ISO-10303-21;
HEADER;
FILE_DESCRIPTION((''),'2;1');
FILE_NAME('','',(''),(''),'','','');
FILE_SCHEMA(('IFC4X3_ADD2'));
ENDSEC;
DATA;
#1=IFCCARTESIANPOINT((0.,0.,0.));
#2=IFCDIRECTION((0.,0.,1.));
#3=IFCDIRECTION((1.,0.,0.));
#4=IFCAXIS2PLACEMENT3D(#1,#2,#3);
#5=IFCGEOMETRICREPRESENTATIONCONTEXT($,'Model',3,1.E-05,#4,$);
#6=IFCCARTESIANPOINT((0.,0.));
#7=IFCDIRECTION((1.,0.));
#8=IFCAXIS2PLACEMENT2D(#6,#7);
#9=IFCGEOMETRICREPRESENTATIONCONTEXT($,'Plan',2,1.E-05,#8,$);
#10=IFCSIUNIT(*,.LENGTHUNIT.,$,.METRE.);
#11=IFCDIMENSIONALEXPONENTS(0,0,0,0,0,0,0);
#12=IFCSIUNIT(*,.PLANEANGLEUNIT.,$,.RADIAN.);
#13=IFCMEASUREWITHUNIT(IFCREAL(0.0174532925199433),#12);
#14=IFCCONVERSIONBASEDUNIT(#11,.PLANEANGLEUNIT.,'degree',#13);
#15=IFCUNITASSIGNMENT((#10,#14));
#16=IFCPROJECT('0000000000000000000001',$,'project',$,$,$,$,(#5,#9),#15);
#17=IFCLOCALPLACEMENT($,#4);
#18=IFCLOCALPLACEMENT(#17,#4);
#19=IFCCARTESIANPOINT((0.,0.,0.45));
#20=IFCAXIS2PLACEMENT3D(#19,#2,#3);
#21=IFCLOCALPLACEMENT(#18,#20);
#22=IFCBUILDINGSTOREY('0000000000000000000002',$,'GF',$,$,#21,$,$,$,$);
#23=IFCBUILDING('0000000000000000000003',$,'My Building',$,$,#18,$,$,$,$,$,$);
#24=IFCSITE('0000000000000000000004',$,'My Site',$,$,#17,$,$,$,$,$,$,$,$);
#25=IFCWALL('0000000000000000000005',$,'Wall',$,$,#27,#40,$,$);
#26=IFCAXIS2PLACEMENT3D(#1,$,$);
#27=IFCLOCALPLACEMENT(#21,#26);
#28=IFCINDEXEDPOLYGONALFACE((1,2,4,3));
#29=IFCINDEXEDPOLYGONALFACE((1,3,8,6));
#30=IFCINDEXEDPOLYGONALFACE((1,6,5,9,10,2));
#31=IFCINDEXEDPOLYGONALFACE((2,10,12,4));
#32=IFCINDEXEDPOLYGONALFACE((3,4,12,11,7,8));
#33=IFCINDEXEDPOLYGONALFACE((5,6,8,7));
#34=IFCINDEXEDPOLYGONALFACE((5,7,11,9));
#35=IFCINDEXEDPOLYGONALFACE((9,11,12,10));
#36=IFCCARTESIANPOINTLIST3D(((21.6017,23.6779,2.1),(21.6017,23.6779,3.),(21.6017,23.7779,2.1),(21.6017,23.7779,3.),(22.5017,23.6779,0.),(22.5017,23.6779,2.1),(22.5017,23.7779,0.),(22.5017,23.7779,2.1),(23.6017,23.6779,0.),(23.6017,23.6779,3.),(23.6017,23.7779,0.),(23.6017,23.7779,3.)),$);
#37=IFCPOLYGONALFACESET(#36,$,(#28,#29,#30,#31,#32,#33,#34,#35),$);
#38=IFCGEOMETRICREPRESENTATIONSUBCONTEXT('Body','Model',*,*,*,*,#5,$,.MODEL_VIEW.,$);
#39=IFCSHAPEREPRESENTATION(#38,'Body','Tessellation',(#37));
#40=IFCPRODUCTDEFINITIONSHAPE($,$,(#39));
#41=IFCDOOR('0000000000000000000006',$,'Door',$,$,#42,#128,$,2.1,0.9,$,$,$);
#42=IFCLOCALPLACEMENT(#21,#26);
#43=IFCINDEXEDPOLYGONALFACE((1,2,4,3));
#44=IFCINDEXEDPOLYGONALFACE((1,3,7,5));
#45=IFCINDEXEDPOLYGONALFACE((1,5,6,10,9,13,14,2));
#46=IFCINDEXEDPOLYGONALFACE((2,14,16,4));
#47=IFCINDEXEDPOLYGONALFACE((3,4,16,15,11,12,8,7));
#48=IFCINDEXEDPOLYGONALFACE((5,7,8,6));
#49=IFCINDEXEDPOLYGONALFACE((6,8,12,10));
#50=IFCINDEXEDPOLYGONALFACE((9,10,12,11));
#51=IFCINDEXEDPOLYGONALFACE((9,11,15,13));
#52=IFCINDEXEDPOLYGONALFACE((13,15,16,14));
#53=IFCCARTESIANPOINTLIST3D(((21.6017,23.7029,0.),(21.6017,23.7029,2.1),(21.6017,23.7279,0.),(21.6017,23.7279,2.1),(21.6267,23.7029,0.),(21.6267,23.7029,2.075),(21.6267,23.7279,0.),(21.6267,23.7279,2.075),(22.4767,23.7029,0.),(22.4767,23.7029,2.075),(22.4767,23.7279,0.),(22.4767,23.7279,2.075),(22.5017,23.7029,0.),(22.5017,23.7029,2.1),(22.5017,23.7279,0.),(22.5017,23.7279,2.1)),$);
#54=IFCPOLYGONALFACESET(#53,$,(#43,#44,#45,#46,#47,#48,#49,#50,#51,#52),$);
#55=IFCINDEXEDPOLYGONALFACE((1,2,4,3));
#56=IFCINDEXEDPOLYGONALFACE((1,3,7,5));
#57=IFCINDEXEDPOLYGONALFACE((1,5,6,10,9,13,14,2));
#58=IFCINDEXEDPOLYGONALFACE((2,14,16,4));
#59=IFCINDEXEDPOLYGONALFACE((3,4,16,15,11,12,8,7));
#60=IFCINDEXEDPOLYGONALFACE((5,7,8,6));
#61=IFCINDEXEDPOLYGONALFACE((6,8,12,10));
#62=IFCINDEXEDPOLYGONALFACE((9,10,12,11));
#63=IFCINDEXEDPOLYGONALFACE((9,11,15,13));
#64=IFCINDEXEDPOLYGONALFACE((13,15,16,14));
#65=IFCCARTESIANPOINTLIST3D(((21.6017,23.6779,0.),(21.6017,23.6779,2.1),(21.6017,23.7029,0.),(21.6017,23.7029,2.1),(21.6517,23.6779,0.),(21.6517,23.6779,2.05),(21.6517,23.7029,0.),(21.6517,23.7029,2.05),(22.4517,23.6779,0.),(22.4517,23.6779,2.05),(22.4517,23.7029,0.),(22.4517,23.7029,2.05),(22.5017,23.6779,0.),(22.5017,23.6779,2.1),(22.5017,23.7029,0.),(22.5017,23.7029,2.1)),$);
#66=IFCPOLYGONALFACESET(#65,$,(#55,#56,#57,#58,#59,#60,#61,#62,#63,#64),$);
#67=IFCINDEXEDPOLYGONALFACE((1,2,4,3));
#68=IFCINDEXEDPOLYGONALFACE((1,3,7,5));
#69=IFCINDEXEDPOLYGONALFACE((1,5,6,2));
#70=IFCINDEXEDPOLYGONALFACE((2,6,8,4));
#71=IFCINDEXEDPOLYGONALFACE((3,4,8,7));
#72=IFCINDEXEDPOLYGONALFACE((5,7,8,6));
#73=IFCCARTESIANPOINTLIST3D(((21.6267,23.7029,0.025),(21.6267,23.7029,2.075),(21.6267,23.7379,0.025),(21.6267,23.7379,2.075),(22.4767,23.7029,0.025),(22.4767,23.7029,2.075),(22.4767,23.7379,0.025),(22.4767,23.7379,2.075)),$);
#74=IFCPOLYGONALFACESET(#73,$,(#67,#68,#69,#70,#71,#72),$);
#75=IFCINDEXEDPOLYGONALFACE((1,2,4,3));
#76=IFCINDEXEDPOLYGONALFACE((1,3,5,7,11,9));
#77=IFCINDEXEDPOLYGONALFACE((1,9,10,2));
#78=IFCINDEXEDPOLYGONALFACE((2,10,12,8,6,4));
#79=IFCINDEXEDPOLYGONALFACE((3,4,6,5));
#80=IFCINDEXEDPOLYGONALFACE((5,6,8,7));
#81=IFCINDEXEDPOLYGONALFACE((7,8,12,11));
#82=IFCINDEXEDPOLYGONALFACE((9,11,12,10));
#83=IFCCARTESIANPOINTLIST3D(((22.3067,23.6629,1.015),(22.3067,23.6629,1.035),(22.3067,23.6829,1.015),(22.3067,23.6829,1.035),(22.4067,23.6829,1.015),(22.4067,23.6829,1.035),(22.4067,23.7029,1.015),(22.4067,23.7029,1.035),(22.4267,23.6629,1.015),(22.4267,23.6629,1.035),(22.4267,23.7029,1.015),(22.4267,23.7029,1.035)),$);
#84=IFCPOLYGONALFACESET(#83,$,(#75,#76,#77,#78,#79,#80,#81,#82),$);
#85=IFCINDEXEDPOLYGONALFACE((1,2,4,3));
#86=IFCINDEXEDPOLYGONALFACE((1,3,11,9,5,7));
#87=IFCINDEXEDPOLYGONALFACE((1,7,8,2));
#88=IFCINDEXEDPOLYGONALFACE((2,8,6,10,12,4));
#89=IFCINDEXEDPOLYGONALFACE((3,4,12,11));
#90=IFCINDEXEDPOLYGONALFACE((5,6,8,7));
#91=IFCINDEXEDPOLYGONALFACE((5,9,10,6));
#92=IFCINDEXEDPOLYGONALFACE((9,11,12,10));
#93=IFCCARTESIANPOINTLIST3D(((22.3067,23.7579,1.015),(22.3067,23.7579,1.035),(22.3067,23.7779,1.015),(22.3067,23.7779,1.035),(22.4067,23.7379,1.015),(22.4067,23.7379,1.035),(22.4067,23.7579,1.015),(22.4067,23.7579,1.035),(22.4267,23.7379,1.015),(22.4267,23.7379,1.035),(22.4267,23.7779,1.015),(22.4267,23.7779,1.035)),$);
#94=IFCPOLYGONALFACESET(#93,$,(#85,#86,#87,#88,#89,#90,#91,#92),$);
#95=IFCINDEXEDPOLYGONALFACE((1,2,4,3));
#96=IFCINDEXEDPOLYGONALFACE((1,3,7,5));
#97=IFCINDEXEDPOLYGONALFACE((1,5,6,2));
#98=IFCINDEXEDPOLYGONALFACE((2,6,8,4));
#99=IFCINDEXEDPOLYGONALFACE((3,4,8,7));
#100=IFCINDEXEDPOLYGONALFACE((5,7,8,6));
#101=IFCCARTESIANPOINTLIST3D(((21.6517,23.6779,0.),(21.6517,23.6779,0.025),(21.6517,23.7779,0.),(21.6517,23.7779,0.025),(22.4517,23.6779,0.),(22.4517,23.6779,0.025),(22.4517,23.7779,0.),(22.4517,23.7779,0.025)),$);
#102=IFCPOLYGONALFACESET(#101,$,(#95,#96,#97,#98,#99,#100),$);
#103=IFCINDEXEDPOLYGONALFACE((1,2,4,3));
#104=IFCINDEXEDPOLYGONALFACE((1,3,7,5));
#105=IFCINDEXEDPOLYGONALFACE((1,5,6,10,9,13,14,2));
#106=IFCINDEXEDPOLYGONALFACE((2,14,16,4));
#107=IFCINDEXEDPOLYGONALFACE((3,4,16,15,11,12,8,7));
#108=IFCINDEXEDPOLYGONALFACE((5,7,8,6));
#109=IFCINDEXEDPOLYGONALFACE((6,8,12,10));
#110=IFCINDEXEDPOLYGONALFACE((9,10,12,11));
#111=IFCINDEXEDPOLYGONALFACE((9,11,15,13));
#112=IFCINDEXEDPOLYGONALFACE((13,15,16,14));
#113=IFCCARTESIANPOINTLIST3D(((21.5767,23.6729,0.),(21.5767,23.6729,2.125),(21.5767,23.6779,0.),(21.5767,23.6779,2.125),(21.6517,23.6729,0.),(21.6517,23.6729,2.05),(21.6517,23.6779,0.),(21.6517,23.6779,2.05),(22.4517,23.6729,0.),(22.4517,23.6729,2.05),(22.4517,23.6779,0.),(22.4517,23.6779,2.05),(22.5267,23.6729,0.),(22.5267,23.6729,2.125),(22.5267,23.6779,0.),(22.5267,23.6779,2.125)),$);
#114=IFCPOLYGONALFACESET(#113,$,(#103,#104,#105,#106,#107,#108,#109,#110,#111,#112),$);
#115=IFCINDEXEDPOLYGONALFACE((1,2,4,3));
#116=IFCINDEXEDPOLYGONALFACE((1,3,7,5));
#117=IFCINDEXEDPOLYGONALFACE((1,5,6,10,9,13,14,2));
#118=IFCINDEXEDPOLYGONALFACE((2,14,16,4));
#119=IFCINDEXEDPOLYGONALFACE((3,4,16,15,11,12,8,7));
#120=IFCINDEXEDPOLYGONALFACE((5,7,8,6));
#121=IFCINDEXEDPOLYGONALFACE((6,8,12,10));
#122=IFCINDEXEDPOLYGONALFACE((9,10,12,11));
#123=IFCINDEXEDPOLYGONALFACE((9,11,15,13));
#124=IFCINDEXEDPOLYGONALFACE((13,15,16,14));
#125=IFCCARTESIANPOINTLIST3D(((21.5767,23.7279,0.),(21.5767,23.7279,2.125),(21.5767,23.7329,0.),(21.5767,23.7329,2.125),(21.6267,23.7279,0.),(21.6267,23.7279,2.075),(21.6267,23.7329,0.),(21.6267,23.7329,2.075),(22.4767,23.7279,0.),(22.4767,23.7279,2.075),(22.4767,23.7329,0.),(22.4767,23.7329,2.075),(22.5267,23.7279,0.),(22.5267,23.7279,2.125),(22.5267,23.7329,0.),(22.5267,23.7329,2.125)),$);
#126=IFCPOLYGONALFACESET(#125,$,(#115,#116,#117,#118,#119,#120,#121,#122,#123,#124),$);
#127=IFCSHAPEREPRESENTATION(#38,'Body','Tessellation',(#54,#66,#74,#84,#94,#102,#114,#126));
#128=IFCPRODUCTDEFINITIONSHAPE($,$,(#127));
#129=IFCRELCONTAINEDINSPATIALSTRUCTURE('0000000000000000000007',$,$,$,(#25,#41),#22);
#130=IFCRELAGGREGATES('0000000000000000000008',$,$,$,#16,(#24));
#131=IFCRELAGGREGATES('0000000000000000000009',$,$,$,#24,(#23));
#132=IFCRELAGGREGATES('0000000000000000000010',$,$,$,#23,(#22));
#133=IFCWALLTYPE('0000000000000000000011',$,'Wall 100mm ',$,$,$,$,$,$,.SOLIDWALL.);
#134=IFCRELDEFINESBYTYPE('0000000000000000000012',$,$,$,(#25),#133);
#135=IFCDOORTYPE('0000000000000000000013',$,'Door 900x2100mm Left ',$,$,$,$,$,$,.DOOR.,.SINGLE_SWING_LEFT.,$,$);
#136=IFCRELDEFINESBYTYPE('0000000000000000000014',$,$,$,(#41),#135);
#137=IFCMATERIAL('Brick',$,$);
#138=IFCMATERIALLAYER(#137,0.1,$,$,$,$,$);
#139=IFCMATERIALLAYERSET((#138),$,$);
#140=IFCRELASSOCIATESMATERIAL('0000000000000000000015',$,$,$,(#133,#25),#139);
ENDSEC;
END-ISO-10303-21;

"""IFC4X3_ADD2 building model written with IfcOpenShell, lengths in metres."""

from ifc_helpers import new_model, entity, si_unit, converted_unit, frame, origin_with_axes, origin_2d_with_axis, place, context, subcontext, project, spatial, line, indexed_curve, outline, extrude, shape, source, transform, mapped, material, layer, layer_set, layer_usage, type_object, type_shapes, element, fill, save


model = new_model("IFC4X3_ADD2")

# Units and contexts
model_context = context("Model", 3, precision=1e-05, world=origin_with_axes())
plan_context = context("Plan", 2, precision=1e-05, world=origin_2d_with_axis())
body_context_1 = subcontext(model_context, "Body", "Model", "MODEL_VIEW")
body_context_2 = subcontext(plan_context, "Body", "Plan", "PLAN_VIEW")
ifc_project = project(units=[si_unit("LENGTHUNIT", "METRE"), converted_unit("PLANEANGLEUNIT", "degree", entity("IfcReal", 0.0174532925199433), si_unit("PLANEANGLEUNIT", "RADIAN"), dimensions=[0, 0, 0, 0, 0, 0, 0])], contexts=[model_context, plan_context])

# Site, building, storey
site_placement = place(None, origin_with_axes())
site = spatial("IfcSite", under=ifc_project, at=site_placement, Name="My Site")
building_placement = place(site_placement, origin_with_axes())
building = spatial("IfcBuilding", under=site, at=building_placement, Name="My Building")
storey_placement = place(building_placement, frame((0.0, 0.0, 0.45), z_axis=(0.0, 0.0, 1.0), x_axis=(1.0, 0.0, 0.0)))
storey = spatial("IfcBuildingStorey", under=building, at=storey_placement, Name="GF")

# Shared definitions
ifc_material = material(Name="Brick")

# Shared definitions
ifc_layer_1 = layer(ifc_material, 0.1)
ifc_layer_set_1 = layer_set([ifc_layer_1])
wall_type_1 = type_object("IfcWallType", Name="Wall 100mm ", PredefinedType="SOLIDWALL", material=ifc_layer_set_1)

# Wall, opening, door
ifc_layer_usage_1 = layer_usage(ifc_layer_set_1, "AXIS2", "POSITIVE", 0.0)
wall_1_placement = place(storey_placement, frame((21.6017, 23.6779, 0.0), z_axis=(0.0, 0.0, 1.0), x_axis=(1.0, 0.0, 0.0)))
wall_1 = element("IfcWall", 1, at=wall_1_placement, inside=storey, type_object=wall_type_1, material=ifc_layer_usage_1, Name="Wall", context=body_context_1, shape_type="SweptSolid", body=[
    extrude(outline(indexed_curve([(0.0, 0.0), (0.0, 0.1), (2.0, 0.1), (2.0, 0.0), (0.0, 0.0)], self_intersect=False)), origin_with_axes(), (0.0, 0.0, 1.0), 3.0),
])
shared_shape_1 = source(origin_with_axes(), body_context_1, "Body", "SweptSolid", [
    extrude(outline(indexed_curve([(0.0, 0.0), (0.9, 0.0), (0.9, 2.1), (0.0, 2.1)], segments=[line(1, 2, 3, 4, 1)])), frame((0.0, -0.6, 0.0), z_axis=(0.0, -1.0, 0.0), x_axis=(1.0, 0.0, 0.0)), (0.0, 0.0, -1.0), 1.2),
])
opening_1_placement = place(wall_1_placement, frame((0.0, 0.0, 0.0), z_axis=(0.0, 0.0, 1.0), x_axis=(1.0, 0.0, 0.0)))
opening_1 = element("IfcOpeningElement", 2, at=opening_1_placement, cuts=wall_1, PredefinedType="OPENING", context=body_context_1, shape_type="MappedRepresentation", body=[
    mapped(shared_shape_1, transform((0.0, 0.0, 0.0), x_axis=(1.0, 0.0, 0.0), y_axis=(0.0, 1.0, 0.0), z_axis=(0.0, 0.0, 1.0), scale=1.0)),
])
door_type_1 = type_object("IfcDoorType", Name="Door 900x2100mm Left ", OperationType="SINGLE_SWING_LEFT", PredefinedType="DOOR")
shared_shape_2 = source(origin_with_axes(), body_context_1, "Body", "SweptSolid", [
    extrude(outline(indexed_curve([(0.0, 0.0), (0.0, 2.1), (0.9, 2.1), (0.9, 0.0), (0.875, 0.0), (0.875, 2.075), (0.025, 2.075), (0.025, 0.0)], segments=[line(1, 2, 3, 4, 5, 6, 7, 8, 1)])), frame((0.0, 0.025, 0.0), z_axis=(0.0, -1.0, 0.0), x_axis=(1.0, 0.0, 0.0)), (0.0, 0.0, -1.0), 0.025),
    extrude(outline(indexed_curve([(0.0, 0.0), (0.0, 2.1), (0.9, 2.1), (0.9, 0.0), (0.85, 0.0), (0.85, 2.05), (0.05, 2.05), (0.05, 0.0)], segments=[line(1, 2, 3, 4, 5, 6, 7, 8, 1)])), frame((0.0, 0.0, 0.0), z_axis=(0.0, -1.0, 0.0), x_axis=(1.0, 0.0, 0.0)), (0.0, 0.0, -1.0), 0.025),
    extrude(outline(indexed_curve([(0.0, 0.0), (0.85, 0.0), (0.85, 0.035), (0.0, 0.035)], segments=[line(1, 2, 3, 4, 1)])), frame((0.025, 0.025, 0.025), z_axis=(0.0, 0.0, 1.0), x_axis=(1.0, 0.0, 0.0)), (0.0, 0.0, 1.0), 2.05),
    extrude(outline(indexed_curve([(0.0, 0.0), (0.0, -0.04), (-0.12, -0.04), (-0.12, -0.02), (-0.02, -0.02), (-0.02, 0.0)], segments=[line(1, 2, 3, 4, 5, 6, 1)])), frame((0.825, 0.025, 1.015), z_axis=(0.0, 0.0, 1.0), x_axis=(1.0, 0.0, 0.0)), (0.0, 0.0, 1.0), 0.02),
    extrude(outline(indexed_curve([(0.0, 0.0), (0.0, 0.04), (-0.12, 0.04), (-0.12, 0.02), (-0.02, 0.02), (-0.02, 0.0)], segments=[line(1, 2, 3, 4, 5, 6, 1)])), frame((0.825, 0.06, 1.015), z_axis=(0.0, 0.0, 1.0), x_axis=(1.0, 0.0, 0.0)), (0.0, 0.0, 1.0), 0.02),
    extrude(outline(indexed_curve([(0.0, 0.0), (0.8, 0.0), (0.8, 0.1), (0.0, 0.1)], segments=[line(1, 2, 3, 4, 1)])), frame((0.05, 0.0, 0.0), z_axis=(0.0, 0.0, 1.0), x_axis=(1.0, 0.0, 0.0)), (0.0, 0.0, 1.0), 0.025),
    extrude(outline(indexed_curve([(0.0, 0.0), (0.0, 2.125), (0.95, 2.125), (0.95, 0.0), (0.875, 0.0), (0.875, 2.05), (0.075, 2.05), (0.075, 0.0)], segments=[line(1, 2, 3, 4, 5, 6, 7, 8, 1)])), frame((-0.025, -0.005, 0.0), z_axis=(0.0, -1.0, 0.0), x_axis=(1.0, 0.0, 0.0)), (0.0, 0.0, -1.0), 0.005),
    extrude(outline(indexed_curve([(0.0, 0.0), (0.0, 2.125), (0.95, 2.125), (0.95, 0.0), (0.9, 0.0), (0.9, 2.075), (0.05, 2.075), (0.05, 0.0)], segments=[line(1, 2, 3, 4, 5, 6, 7, 8, 1)])), frame((-0.025, 0.05, 0.0), z_axis=(0.0, -1.0, 0.0), x_axis=(1.0, 0.0, 0.0)), (0.0, 0.0, -1.0), 0.005),
])
shared_shape_3 = source(origin_with_axes(), body_context_2, "Body", "Curve2D", [
    entity("IfcIndexedPolyCurve", entity("IfcCartesianPointList2D", [[0.0, 0.0], [0.0, 0.05], [0.025, 0.05], [0.025, 0.025], [0.05, 0.025], [0.05, 0.0]]), [entity("IfcLineIndex", [1, 2, 3, 4, 5, 6, 1])]),
    entity("IfcIndexedPolyCurve", entity("IfcCartesianPointList2D", [[0.9, 0.0], [0.9, 0.05], [0.875, 0.05], [0.875, 0.025], [0.85, 0.025], [0.85, 0.0]]), [entity("IfcLineIndex", [1, 2, 3, 4, 5, 6, 1])]),
    entity("IfcTrimmedCurve", entity("IfcEllipse", entity("IfcAxis2Placement2D", entity("IfcCartesianPoint", [0.06, 0.05]), entity("IfcDirection", [1.0, 0.0])), 0.815, 0.85), [entity("IfcCartesianPoint", [0.875, 0.05])], [entity("IfcCartesianPoint", [0.06, 0.9])], True, "CARTESIAN"),
    entity("IfcIndexedPolyCurve", entity("IfcCartesianPointList2D", [[0.025, 0.05], [0.06, 0.05], [0.06, 0.9], [0.025, 0.9]]), [entity("IfcLineIndex", [1, 2, 3, 4, 1])]),
])
type_shapes(door_type_1, [shared_shape_2, shared_shape_3])
door_1_placement = place(opening_1_placement, origin_with_axes())
door_1 = element("IfcDoor", 3, at=door_1_placement, inside=storey, type_object=door_type_1, Name="Door", OverallHeight=2.1, OverallWidth=0.9, shapes=[
    shape(body_context_1, "Body", "MappedRepresentation", [mapped(shared_shape_2, transform((0.0, 0.0, 0.0), x_axis=(1.0, 0.0, 0.0), y_axis=(0.0, 1.0, 0.0), z_axis=(0.0, 0.0, 1.0), scale=1.0))]),
    shape(body_context_2, "Body", "MappedRepresentation", [mapped(shared_shape_3, transform((0.0, 0.0, 0.0), x_axis=(1.0, 0.0, 0.0), y_axis=(0.0, 1.0, 0.0), z_axis=(0.0, 0.0, 1.0), scale=1.0))]),
])
fill(opening_1, door_1)

save(model, "model.ifc")
